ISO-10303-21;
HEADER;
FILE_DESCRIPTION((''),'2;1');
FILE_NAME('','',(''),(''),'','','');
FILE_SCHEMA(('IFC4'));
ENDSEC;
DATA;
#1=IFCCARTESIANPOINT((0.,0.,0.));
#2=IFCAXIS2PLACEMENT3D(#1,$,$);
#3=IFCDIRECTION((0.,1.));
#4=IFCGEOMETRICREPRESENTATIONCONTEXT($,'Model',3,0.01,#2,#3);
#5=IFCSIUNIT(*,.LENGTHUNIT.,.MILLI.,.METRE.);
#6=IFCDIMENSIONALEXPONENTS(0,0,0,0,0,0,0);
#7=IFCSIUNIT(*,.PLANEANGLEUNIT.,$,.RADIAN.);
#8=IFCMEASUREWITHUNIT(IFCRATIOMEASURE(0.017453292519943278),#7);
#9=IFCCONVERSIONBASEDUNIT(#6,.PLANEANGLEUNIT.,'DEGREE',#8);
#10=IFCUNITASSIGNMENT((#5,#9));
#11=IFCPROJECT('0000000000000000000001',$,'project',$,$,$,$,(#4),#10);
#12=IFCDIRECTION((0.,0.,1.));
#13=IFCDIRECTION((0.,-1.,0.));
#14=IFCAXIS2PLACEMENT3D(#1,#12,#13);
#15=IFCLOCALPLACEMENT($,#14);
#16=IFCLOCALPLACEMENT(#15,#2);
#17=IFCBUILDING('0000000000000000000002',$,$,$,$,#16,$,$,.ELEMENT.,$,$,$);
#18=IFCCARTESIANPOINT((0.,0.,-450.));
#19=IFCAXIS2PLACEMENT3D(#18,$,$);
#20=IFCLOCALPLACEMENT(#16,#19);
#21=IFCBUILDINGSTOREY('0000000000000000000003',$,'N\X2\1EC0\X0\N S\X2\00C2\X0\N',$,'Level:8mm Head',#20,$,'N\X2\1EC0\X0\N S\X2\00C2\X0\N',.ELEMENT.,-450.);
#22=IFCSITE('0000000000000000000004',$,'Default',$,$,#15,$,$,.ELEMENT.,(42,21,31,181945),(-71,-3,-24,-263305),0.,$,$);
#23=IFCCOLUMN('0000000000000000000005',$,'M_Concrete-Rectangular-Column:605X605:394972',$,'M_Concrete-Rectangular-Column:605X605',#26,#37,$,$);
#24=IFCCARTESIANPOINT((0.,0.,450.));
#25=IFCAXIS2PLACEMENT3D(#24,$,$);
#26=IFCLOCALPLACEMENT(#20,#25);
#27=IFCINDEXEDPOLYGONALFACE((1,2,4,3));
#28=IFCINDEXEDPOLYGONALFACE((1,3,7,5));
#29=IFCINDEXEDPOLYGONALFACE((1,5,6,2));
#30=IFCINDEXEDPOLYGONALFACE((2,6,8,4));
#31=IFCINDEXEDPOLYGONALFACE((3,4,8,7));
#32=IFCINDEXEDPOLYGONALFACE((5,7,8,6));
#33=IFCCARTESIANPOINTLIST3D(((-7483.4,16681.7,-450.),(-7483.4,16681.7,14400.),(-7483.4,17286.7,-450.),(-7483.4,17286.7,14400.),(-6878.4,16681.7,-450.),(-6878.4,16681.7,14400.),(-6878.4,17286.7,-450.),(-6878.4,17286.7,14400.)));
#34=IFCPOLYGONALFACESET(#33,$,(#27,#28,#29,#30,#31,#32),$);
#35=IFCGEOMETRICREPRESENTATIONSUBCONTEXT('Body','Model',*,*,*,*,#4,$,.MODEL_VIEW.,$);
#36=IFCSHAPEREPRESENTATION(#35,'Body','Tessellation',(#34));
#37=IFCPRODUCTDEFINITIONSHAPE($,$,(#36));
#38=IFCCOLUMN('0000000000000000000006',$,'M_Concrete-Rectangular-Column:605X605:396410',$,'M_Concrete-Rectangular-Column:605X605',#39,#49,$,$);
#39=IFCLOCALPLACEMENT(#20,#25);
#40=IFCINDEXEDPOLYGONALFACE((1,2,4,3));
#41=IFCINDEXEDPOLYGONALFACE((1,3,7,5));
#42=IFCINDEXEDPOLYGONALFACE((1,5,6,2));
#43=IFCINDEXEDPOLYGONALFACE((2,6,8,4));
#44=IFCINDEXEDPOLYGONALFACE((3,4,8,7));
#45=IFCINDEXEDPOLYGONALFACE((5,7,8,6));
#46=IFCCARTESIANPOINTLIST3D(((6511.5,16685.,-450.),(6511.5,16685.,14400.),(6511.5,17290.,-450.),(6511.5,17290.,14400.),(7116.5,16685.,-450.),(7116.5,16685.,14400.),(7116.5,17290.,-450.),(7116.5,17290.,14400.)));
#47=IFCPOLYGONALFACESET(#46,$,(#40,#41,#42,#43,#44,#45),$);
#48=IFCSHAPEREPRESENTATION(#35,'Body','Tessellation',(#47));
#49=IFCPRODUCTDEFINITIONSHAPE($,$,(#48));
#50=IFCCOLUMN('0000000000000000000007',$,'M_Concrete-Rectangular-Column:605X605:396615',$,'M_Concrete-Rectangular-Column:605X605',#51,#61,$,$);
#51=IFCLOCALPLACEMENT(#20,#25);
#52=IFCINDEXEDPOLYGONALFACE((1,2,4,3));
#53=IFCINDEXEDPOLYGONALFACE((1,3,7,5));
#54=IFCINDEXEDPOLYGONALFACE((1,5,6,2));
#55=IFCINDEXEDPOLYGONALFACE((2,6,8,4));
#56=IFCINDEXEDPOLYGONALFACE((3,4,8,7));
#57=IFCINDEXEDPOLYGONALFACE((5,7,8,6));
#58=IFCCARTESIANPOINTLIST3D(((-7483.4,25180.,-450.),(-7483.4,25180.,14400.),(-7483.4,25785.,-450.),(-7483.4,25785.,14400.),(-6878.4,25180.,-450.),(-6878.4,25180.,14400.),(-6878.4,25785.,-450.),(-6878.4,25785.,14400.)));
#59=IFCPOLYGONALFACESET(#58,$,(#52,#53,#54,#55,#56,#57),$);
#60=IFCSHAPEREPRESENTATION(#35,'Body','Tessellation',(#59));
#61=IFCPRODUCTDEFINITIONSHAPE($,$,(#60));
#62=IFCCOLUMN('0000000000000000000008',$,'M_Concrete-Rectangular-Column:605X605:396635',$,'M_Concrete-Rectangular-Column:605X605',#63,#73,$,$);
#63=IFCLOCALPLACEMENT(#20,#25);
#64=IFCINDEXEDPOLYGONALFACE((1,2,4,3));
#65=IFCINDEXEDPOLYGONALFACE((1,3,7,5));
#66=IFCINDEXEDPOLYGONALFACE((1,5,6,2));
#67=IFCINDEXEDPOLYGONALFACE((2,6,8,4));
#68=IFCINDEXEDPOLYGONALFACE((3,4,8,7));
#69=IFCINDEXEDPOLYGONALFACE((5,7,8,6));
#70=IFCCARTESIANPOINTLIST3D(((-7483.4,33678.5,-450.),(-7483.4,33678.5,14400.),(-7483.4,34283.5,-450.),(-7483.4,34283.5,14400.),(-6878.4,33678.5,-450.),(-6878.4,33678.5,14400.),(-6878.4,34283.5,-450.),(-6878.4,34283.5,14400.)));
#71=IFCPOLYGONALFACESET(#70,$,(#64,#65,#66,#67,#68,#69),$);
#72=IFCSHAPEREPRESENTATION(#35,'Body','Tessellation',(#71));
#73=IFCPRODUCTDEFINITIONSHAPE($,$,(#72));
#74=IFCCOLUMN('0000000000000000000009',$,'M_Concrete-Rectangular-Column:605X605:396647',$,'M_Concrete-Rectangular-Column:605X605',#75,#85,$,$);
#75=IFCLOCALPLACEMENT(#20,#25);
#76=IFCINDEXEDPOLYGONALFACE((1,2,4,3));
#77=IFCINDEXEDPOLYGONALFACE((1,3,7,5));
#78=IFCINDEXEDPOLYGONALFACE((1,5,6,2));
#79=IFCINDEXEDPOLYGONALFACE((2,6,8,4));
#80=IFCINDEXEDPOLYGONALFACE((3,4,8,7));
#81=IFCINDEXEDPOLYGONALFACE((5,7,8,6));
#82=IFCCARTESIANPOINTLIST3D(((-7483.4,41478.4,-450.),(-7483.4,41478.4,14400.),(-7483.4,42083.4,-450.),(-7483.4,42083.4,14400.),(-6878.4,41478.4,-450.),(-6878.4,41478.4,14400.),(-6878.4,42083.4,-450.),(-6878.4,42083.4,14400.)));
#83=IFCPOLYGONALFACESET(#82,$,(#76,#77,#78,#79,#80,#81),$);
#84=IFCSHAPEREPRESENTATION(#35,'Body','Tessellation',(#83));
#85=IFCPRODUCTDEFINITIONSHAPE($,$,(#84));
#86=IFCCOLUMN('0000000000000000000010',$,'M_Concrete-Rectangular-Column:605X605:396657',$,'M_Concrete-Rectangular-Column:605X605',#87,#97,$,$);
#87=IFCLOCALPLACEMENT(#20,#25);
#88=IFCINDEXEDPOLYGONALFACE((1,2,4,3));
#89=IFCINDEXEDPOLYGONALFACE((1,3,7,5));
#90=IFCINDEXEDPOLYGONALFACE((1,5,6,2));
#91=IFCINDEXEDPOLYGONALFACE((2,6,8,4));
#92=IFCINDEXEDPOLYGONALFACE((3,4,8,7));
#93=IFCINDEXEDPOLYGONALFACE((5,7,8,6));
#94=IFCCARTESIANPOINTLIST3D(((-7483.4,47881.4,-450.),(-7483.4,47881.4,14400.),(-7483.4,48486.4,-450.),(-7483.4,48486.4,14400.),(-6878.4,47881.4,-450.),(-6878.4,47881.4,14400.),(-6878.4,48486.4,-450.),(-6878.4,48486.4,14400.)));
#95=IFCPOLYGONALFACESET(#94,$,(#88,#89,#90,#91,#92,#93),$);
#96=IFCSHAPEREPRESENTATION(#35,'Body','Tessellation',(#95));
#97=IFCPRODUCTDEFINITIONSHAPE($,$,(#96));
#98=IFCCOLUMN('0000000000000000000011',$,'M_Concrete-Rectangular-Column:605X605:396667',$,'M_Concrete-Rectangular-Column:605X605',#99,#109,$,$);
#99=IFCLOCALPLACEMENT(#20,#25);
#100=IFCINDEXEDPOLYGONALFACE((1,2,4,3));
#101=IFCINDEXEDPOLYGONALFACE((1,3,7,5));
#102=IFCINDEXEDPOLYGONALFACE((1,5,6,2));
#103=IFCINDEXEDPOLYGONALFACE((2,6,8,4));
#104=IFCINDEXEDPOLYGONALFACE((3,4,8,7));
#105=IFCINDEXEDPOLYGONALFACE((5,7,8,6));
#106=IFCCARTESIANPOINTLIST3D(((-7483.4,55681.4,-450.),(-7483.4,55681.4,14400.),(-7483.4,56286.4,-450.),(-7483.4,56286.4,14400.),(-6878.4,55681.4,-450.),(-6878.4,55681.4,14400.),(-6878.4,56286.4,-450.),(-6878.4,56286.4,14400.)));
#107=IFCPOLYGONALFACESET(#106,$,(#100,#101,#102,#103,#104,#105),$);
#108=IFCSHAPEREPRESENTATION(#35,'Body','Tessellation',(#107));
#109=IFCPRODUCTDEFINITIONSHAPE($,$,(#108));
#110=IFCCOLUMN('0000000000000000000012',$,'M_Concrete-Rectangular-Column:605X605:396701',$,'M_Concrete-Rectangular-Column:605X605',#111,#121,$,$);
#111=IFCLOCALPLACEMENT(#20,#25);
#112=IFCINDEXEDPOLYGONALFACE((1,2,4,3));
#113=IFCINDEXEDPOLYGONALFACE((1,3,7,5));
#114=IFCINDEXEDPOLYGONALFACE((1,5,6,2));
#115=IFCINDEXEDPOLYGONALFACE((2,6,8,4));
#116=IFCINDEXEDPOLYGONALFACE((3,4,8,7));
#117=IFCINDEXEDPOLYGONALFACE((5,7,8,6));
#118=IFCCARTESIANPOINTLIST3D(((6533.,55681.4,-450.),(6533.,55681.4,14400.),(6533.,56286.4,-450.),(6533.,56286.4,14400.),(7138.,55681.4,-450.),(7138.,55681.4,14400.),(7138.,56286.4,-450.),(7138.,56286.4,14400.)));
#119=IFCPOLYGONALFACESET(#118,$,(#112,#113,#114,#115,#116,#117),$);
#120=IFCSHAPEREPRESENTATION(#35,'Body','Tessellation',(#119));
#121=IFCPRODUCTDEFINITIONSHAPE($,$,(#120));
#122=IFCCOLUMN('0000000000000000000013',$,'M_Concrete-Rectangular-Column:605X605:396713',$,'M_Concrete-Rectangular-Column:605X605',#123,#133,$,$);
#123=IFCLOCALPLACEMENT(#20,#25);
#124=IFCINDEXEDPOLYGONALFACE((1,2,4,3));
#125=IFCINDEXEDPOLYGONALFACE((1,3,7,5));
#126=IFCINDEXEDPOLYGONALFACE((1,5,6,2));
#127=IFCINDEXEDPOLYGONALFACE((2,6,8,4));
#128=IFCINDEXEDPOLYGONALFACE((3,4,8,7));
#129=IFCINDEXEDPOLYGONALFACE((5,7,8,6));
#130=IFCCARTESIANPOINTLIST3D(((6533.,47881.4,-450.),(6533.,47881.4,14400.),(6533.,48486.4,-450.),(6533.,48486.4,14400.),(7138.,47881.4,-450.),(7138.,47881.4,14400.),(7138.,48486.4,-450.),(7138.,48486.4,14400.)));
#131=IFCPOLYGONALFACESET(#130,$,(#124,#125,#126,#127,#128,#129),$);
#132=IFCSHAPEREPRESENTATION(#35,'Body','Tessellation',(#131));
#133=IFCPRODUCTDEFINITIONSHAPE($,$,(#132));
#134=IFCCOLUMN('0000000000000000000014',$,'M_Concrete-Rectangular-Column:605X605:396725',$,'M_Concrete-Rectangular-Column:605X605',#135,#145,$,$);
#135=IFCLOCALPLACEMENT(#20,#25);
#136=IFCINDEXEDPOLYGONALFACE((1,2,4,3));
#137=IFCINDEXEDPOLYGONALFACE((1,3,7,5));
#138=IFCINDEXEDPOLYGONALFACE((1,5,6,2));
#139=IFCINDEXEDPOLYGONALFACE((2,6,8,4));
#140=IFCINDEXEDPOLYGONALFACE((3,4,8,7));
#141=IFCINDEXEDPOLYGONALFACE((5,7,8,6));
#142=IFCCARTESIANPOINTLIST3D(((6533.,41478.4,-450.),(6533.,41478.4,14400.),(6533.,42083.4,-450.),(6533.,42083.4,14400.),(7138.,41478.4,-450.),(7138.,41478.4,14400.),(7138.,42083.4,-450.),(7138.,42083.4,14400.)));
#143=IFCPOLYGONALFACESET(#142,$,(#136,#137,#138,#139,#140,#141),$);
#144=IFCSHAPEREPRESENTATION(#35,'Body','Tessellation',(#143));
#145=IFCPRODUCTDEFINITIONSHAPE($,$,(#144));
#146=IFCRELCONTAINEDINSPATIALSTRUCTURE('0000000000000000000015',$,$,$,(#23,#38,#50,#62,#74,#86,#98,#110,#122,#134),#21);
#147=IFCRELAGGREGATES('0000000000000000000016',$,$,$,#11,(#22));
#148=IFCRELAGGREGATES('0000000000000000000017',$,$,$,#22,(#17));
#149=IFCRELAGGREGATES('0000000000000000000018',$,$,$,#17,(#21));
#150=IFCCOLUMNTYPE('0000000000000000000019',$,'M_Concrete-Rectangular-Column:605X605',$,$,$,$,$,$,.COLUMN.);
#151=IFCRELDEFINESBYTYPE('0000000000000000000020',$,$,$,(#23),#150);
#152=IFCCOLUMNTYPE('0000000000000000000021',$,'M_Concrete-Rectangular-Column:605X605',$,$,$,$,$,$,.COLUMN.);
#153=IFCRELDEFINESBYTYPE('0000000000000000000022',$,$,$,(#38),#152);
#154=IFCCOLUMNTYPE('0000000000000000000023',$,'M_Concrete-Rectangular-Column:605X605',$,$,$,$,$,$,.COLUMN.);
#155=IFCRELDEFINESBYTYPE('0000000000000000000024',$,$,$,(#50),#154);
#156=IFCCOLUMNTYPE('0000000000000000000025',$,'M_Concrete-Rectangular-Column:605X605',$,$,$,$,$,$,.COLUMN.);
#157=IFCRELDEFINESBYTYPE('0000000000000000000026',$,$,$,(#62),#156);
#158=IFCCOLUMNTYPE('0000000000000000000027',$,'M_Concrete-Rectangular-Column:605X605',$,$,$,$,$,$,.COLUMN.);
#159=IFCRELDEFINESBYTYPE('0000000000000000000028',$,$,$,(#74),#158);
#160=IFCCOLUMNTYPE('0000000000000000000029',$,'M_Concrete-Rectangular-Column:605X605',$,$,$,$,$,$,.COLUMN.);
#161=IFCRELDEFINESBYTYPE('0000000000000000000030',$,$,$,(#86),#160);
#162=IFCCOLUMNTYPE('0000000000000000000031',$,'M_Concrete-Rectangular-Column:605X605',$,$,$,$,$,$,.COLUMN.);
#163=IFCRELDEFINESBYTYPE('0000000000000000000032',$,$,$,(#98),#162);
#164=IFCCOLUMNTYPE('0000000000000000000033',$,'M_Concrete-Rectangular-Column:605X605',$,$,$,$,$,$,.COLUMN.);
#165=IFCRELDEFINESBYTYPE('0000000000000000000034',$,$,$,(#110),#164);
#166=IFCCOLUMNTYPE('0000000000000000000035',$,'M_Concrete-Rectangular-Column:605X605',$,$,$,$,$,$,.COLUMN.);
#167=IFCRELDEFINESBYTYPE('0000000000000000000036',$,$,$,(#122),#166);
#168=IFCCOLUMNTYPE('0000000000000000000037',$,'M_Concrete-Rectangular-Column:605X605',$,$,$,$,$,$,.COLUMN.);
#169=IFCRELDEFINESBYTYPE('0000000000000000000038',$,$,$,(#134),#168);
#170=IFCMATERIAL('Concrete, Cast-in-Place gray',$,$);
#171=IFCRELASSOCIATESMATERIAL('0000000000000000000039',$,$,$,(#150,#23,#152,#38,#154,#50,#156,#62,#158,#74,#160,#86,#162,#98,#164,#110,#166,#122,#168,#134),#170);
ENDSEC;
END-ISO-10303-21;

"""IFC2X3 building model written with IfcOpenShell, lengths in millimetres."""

from ifc_helpers import new_model, entity, si_unit, converted_unit, direction, frame, frame_2d, origin, origin_2d_with_axis, place, context, subcontext, project, spatial, rectangle, extrude, source, transform, mapped, material, type_object, type_shapes, element, save


model = new_model("IFC2X3")

# Units and contexts
model_context = context("Model", 3, precision=0.01, world=origin(), true_north=direction((0.0, 1.0)))
body_context = subcontext(model_context, "Body", "Model", "MODEL_VIEW")
ifc_project = project(units=[si_unit("LENGTHUNIT", "METRE", prefix="MILLI"), converted_unit("PLANEANGLEUNIT", "DEGREE", entity("IfcRatioMeasure", 0.017453292519943278), si_unit("PLANEANGLEUNIT", "RADIAN"), dimensions=[0, 0, 0, 0, 0, 0, 0])], contexts=[model_context])

# Site, building, storey
site_placement = place(None, frame((0.0, 0.0, 0.0), z_axis=(0.0, 0.0, 1.0), x_axis=(0.0, -1.0, 0.0)))
site = spatial("IfcSite", under=ifc_project, at=site_placement, Name="Default", CompositionType="ELEMENT", RefLatitude=(42, 21, 31, 181945), RefLongitude=(-71, -3, -24, -263305), RefElevation=0.0)
building_placement = place(site_placement, origin())
building = spatial("IfcBuilding", under=site, at=building_placement, CompositionType="ELEMENT")
storey_placement = place(building_placement, frame((0.0, 0.0, -450.0)))
storey = spatial("IfcBuildingStorey", under=building, at=storey_placement, Name="NỀN SÂN", ObjectType="Level:8mm Head", LongName="NỀN SÂN", CompositionType="ELEMENT", Elevation=-450.0)

# Columns
ifc_material_1 = material(Name="Concrete, Cast-in-Place gray")
column_type_1 = type_object("IfcColumnType", Name="M_Concrete-Rectangular-Column:605X605", PredefinedType="COLUMN", material=ifc_material_1)
shared_shape_1 = source(origin(), body_context, "Body", "SweptSolid", [
    extrude(rectangle(XDim=605.0, YDim=605.0, at=frame_2d((0.0, 0.0), x_axis=(1.0, 0.0))), frame((-7180.9, 16984.2, -450.0), z_axis=(0.0, 0.0, 1.0), x_axis=(0.0, -1.0, 0.0)), (0.0, 0.0, 1.0), 14850.0),
])
type_shapes(column_type_1, [shared_shape_1])
column_1_placement = place(storey_placement, frame((0.0, 0.0, 450.0)))
element("IfcColumn", 1, at=column_1_placement, inside=storey, type_object=column_type_1, material=ifc_material_1, Name="M_Concrete-Rectangular-Column:605X605:394972", ObjectType="M_Concrete-Rectangular-Column:605X605", context=body_context, shape_type="MappedRepresentation", body=[
    mapped(shared_shape_1, transform((0.0, 0.0, 0.0), scale=1.0)),
])
column_type_2 = type_object("IfcColumnType", Name="M_Concrete-Rectangular-Column:605X605", PredefinedType="COLUMN", material=ifc_material_1)
shared_shape_2 = source(origin(), body_context, "Body", "SweptSolid", [
    extrude(rectangle(XDim=605.0, YDim=605.0, at=frame_2d((0.0, 0.0), x_axis=(1.0, 0.0))), frame((6814.0, 16987.5, -450.0), z_axis=(0.0, 0.0, 1.0), x_axis=(0.0, -1.0, 0.0)), (0.0, 0.0, 1.0), 14850.0),
])
type_shapes(column_type_2, [shared_shape_2])
column_2_placement = place(storey_placement, frame((0.0, 0.0, 450.0)))
element("IfcColumn", 2, at=column_2_placement, inside=storey, type_object=column_type_2, material=ifc_material_1, Name="M_Concrete-Rectangular-Column:605X605:396410", ObjectType="M_Concrete-Rectangular-Column:605X605", context=body_context, shape_type="MappedRepresentation", body=[
    mapped(shared_shape_2, transform((0.0, 0.0, 0.0), scale=1.0)),
])
column_type_3 = type_object("IfcColumnType", Name="M_Concrete-Rectangular-Column:605X605", PredefinedType="COLUMN", material=ifc_material_1)
shared_shape_3 = source(origin(), body_context, "Body", "SweptSolid", [
    extrude(rectangle(XDim=605.0, YDim=605.0, at=frame_2d((0.0, 0.0), x_axis=(1.0, 0.0))), frame((-7180.9, 25482.5, -450.0), z_axis=(0.0, 0.0, 1.0), x_axis=(0.0, -1.0, 0.0)), (0.0, 0.0, 1.0), 14850.0),
])
type_shapes(column_type_3, [shared_shape_3])
column_3_placement = place(storey_placement, frame((0.0, 0.0, 450.0)))
element("IfcColumn", 3, at=column_3_placement, inside=storey, type_object=column_type_3, material=ifc_material_1, Name="M_Concrete-Rectangular-Column:605X605:396615", ObjectType="M_Concrete-Rectangular-Column:605X605", context=body_context, shape_type="MappedRepresentation", body=[
    mapped(shared_shape_3, transform((0.0, 0.0, 0.0), scale=1.0)),
])
column_type_4 = type_object("IfcColumnType", Name="M_Concrete-Rectangular-Column:605X605", PredefinedType="COLUMN", material=ifc_material_1)
shared_shape_4 = source(origin(), body_context, "Body", "SweptSolid", [
    extrude(rectangle(XDim=605.0, YDim=605.0, at=frame_2d((0.0, 0.0), x_axis=(1.0, 0.0))), frame((-7180.9, 33981.0, -450.0), z_axis=(0.0, 0.0, 1.0), x_axis=(0.0, -1.0, 0.0)), (0.0, 0.0, 1.0), 14850.0),
])
type_shapes(column_type_4, [shared_shape_4])
column_4_placement = place(storey_placement, frame((0.0, 0.0, 450.0)))
element("IfcColumn", 4, at=column_4_placement, inside=storey, type_object=column_type_4, material=ifc_material_1, Name="M_Concrete-Rectangular-Column:605X605:396635", ObjectType="M_Concrete-Rectangular-Column:605X605", context=body_context, shape_type="MappedRepresentation", body=[
    mapped(shared_shape_4, transform((0.0, 0.0, 0.0), scale=1.0)),
])
column_type_5 = type_object("IfcColumnType", Name="M_Concrete-Rectangular-Column:605X605", PredefinedType="COLUMN", material=ifc_material_1)
shared_shape_5 = source(origin(), body_context, "Body", "SweptSolid", [
    extrude(rectangle(XDim=605.0, YDim=605.0, at=frame_2d((0.0, 0.0), x_axis=(1.0, 0.0))), frame((-7180.9, 41780.9, -450.0), z_axis=(0.0, 0.0, 1.0), x_axis=(0.0, -1.0, 0.0)), (0.0, 0.0, 1.0), 14850.0),
])
type_shapes(column_type_5, [shared_shape_5])
column_5_placement = place(storey_placement, frame((0.0, 0.0, 450.0)))
element("IfcColumn", 5, at=column_5_placement, inside=storey, type_object=column_type_5, material=ifc_material_1, Name="M_Concrete-Rectangular-Column:605X605:396647", ObjectType="M_Concrete-Rectangular-Column:605X605", context=body_context, shape_type="MappedRepresentation", body=[
    mapped(shared_shape_5, transform((0.0, 0.0, 0.0), scale=1.0)),
])
column_type_6 = type_object("IfcColumnType", Name="M_Concrete-Rectangular-Column:605X605", PredefinedType="COLUMN", material=ifc_material_1)
shared_shape_6 = source(origin(), body_context, "Body", "SweptSolid", [
    extrude(rectangle(XDim=605.0, YDim=605.0, at=frame_2d((0.0, 0.0), x_axis=(1.0, 0.0))), frame((-7180.9, 48183.9, -450.0), z_axis=(0.0, 0.0, 1.0), x_axis=(0.0, -1.0, 0.0)), (0.0, 0.0, 1.0), 14850.0),
])
type_shapes(column_type_6, [shared_shape_6])
column_6_placement = place(storey_placement, frame((0.0, 0.0, 450.0)))
element("IfcColumn", 6, at=column_6_placement, inside=storey, type_object=column_type_6, material=ifc_material_1, Name="M_Concrete-Rectangular-Column:605X605:396657", ObjectType="M_Concrete-Rectangular-Column:605X605", context=body_context, shape_type="MappedRepresentation", body=[
    mapped(shared_shape_6, transform((0.0, 0.0, 0.0), scale=1.0)),
])
column_type_7 = type_object("IfcColumnType", Name="M_Concrete-Rectangular-Column:605X605", PredefinedType="COLUMN", material=ifc_material_1)
shared_shape_7 = source(origin(), body_context, "Body", "SweptSolid", [
    extrude(rectangle(XDim=605.0, YDim=605.0, at=origin_2d_with_axis()), frame((-7180.9, 55983.9, -450.0), z_axis=(0.0, 0.0, 1.0), x_axis=(0.0, -1.0, 0.0)), (0.0, 0.0, 1.0), 14850.0),
])
type_shapes(column_type_7, [shared_shape_7])
column_7_placement = place(storey_placement, frame((0.0, 0.0, 450.0)))
element("IfcColumn", 7, at=column_7_placement, inside=storey, type_object=column_type_7, material=ifc_material_1, Name="M_Concrete-Rectangular-Column:605X605:396667", ObjectType="M_Concrete-Rectangular-Column:605X605", context=body_context, shape_type="MappedRepresentation", body=[
    mapped(shared_shape_7, transform((0.0, 0.0, 0.0), scale=1.0)),
])
column_type_8 = type_object("IfcColumnType", Name="M_Concrete-Rectangular-Column:605X605", PredefinedType="COLUMN", material=ifc_material_1)
shared_shape_8 = source(origin(), body_context, "Body", "SweptSolid", [
    extrude(rectangle(XDim=605.0, YDim=605.0, at=origin_2d_with_axis()), frame((6835.5, 55983.9, -450.0), z_axis=(0.0, 0.0, 1.0), x_axis=(0.0, -1.0, 0.0)), (0.0, 0.0, 1.0), 14850.0),
])
type_shapes(column_type_8, [shared_shape_8])
column_8_placement = place(storey_placement, frame((0.0, 0.0, 450.0)))
element("IfcColumn", 8, at=column_8_placement, inside=storey, type_object=column_type_8, material=ifc_material_1, Name="M_Concrete-Rectangular-Column:605X605:396701", ObjectType="M_Concrete-Rectangular-Column:605X605", context=body_context, shape_type="MappedRepresentation", body=[
    mapped(shared_shape_8, transform((0.0, 0.0, 0.0), scale=1.0)),
])
column_type_9 = type_object("IfcColumnType", Name="M_Concrete-Rectangular-Column:605X605", PredefinedType="COLUMN", material=ifc_material_1)
shared_shape_9 = source(origin(), body_context, "Body", "SweptSolid", [
    extrude(rectangle(XDim=605.0, YDim=605.0, at=frame_2d((0.0, 0.0), x_axis=(1.0, 0.0))), frame((6835.5, 48183.9, -450.0), z_axis=(0.0, 0.0, 1.0), x_axis=(0.0, -1.0, 0.0)), (0.0, 0.0, 1.0), 14850.0),
])
type_shapes(column_type_9, [shared_shape_9])
column_9_placement = place(storey_placement, frame((0.0, 0.0, 450.0)))
element("IfcColumn", 9, at=column_9_placement, inside=storey, type_object=column_type_9, material=ifc_material_1, Name="M_Concrete-Rectangular-Column:605X605:396713", ObjectType="M_Concrete-Rectangular-Column:605X605", context=body_context, shape_type="MappedRepresentation", body=[
    mapped(shared_shape_9, transform((0.0, 0.0, 0.0), scale=1.0)),
])
column_type_10 = type_object("IfcColumnType", Name="M_Concrete-Rectangular-Column:605X605", PredefinedType="COLUMN", material=ifc_material_1)
shared_shape_10 = source(origin(), body_context, "Body", "SweptSolid", [
    extrude(rectangle(XDim=605.0, YDim=605.0, at=frame_2d((0.0, 0.0), x_axis=(1.0, 0.0))), frame((6835.5, 41780.9, -450.0), z_axis=(0.0, 0.0, 1.0), x_axis=(0.0, -1.0, 0.0)), (0.0, 0.0, 1.0), 14850.0),
])
type_shapes(column_type_10, [shared_shape_10])
column_10_placement = place(storey_placement, frame((0.0, 0.0, 450.0)))
element("IfcColumn", 10, at=column_10_placement, inside=storey, type_object=column_type_10, material=ifc_material_1, Name="M_Concrete-Rectangular-Column:605X605:396725", ObjectType="M_Concrete-Rectangular-Column:605X605", context=body_context, shape_type="MappedRepresentation", body=[
    mapped(shared_shape_10, transform((0.0, 0.0, 0.0), scale=1.0)),
])

save(model, "model.ifc")
